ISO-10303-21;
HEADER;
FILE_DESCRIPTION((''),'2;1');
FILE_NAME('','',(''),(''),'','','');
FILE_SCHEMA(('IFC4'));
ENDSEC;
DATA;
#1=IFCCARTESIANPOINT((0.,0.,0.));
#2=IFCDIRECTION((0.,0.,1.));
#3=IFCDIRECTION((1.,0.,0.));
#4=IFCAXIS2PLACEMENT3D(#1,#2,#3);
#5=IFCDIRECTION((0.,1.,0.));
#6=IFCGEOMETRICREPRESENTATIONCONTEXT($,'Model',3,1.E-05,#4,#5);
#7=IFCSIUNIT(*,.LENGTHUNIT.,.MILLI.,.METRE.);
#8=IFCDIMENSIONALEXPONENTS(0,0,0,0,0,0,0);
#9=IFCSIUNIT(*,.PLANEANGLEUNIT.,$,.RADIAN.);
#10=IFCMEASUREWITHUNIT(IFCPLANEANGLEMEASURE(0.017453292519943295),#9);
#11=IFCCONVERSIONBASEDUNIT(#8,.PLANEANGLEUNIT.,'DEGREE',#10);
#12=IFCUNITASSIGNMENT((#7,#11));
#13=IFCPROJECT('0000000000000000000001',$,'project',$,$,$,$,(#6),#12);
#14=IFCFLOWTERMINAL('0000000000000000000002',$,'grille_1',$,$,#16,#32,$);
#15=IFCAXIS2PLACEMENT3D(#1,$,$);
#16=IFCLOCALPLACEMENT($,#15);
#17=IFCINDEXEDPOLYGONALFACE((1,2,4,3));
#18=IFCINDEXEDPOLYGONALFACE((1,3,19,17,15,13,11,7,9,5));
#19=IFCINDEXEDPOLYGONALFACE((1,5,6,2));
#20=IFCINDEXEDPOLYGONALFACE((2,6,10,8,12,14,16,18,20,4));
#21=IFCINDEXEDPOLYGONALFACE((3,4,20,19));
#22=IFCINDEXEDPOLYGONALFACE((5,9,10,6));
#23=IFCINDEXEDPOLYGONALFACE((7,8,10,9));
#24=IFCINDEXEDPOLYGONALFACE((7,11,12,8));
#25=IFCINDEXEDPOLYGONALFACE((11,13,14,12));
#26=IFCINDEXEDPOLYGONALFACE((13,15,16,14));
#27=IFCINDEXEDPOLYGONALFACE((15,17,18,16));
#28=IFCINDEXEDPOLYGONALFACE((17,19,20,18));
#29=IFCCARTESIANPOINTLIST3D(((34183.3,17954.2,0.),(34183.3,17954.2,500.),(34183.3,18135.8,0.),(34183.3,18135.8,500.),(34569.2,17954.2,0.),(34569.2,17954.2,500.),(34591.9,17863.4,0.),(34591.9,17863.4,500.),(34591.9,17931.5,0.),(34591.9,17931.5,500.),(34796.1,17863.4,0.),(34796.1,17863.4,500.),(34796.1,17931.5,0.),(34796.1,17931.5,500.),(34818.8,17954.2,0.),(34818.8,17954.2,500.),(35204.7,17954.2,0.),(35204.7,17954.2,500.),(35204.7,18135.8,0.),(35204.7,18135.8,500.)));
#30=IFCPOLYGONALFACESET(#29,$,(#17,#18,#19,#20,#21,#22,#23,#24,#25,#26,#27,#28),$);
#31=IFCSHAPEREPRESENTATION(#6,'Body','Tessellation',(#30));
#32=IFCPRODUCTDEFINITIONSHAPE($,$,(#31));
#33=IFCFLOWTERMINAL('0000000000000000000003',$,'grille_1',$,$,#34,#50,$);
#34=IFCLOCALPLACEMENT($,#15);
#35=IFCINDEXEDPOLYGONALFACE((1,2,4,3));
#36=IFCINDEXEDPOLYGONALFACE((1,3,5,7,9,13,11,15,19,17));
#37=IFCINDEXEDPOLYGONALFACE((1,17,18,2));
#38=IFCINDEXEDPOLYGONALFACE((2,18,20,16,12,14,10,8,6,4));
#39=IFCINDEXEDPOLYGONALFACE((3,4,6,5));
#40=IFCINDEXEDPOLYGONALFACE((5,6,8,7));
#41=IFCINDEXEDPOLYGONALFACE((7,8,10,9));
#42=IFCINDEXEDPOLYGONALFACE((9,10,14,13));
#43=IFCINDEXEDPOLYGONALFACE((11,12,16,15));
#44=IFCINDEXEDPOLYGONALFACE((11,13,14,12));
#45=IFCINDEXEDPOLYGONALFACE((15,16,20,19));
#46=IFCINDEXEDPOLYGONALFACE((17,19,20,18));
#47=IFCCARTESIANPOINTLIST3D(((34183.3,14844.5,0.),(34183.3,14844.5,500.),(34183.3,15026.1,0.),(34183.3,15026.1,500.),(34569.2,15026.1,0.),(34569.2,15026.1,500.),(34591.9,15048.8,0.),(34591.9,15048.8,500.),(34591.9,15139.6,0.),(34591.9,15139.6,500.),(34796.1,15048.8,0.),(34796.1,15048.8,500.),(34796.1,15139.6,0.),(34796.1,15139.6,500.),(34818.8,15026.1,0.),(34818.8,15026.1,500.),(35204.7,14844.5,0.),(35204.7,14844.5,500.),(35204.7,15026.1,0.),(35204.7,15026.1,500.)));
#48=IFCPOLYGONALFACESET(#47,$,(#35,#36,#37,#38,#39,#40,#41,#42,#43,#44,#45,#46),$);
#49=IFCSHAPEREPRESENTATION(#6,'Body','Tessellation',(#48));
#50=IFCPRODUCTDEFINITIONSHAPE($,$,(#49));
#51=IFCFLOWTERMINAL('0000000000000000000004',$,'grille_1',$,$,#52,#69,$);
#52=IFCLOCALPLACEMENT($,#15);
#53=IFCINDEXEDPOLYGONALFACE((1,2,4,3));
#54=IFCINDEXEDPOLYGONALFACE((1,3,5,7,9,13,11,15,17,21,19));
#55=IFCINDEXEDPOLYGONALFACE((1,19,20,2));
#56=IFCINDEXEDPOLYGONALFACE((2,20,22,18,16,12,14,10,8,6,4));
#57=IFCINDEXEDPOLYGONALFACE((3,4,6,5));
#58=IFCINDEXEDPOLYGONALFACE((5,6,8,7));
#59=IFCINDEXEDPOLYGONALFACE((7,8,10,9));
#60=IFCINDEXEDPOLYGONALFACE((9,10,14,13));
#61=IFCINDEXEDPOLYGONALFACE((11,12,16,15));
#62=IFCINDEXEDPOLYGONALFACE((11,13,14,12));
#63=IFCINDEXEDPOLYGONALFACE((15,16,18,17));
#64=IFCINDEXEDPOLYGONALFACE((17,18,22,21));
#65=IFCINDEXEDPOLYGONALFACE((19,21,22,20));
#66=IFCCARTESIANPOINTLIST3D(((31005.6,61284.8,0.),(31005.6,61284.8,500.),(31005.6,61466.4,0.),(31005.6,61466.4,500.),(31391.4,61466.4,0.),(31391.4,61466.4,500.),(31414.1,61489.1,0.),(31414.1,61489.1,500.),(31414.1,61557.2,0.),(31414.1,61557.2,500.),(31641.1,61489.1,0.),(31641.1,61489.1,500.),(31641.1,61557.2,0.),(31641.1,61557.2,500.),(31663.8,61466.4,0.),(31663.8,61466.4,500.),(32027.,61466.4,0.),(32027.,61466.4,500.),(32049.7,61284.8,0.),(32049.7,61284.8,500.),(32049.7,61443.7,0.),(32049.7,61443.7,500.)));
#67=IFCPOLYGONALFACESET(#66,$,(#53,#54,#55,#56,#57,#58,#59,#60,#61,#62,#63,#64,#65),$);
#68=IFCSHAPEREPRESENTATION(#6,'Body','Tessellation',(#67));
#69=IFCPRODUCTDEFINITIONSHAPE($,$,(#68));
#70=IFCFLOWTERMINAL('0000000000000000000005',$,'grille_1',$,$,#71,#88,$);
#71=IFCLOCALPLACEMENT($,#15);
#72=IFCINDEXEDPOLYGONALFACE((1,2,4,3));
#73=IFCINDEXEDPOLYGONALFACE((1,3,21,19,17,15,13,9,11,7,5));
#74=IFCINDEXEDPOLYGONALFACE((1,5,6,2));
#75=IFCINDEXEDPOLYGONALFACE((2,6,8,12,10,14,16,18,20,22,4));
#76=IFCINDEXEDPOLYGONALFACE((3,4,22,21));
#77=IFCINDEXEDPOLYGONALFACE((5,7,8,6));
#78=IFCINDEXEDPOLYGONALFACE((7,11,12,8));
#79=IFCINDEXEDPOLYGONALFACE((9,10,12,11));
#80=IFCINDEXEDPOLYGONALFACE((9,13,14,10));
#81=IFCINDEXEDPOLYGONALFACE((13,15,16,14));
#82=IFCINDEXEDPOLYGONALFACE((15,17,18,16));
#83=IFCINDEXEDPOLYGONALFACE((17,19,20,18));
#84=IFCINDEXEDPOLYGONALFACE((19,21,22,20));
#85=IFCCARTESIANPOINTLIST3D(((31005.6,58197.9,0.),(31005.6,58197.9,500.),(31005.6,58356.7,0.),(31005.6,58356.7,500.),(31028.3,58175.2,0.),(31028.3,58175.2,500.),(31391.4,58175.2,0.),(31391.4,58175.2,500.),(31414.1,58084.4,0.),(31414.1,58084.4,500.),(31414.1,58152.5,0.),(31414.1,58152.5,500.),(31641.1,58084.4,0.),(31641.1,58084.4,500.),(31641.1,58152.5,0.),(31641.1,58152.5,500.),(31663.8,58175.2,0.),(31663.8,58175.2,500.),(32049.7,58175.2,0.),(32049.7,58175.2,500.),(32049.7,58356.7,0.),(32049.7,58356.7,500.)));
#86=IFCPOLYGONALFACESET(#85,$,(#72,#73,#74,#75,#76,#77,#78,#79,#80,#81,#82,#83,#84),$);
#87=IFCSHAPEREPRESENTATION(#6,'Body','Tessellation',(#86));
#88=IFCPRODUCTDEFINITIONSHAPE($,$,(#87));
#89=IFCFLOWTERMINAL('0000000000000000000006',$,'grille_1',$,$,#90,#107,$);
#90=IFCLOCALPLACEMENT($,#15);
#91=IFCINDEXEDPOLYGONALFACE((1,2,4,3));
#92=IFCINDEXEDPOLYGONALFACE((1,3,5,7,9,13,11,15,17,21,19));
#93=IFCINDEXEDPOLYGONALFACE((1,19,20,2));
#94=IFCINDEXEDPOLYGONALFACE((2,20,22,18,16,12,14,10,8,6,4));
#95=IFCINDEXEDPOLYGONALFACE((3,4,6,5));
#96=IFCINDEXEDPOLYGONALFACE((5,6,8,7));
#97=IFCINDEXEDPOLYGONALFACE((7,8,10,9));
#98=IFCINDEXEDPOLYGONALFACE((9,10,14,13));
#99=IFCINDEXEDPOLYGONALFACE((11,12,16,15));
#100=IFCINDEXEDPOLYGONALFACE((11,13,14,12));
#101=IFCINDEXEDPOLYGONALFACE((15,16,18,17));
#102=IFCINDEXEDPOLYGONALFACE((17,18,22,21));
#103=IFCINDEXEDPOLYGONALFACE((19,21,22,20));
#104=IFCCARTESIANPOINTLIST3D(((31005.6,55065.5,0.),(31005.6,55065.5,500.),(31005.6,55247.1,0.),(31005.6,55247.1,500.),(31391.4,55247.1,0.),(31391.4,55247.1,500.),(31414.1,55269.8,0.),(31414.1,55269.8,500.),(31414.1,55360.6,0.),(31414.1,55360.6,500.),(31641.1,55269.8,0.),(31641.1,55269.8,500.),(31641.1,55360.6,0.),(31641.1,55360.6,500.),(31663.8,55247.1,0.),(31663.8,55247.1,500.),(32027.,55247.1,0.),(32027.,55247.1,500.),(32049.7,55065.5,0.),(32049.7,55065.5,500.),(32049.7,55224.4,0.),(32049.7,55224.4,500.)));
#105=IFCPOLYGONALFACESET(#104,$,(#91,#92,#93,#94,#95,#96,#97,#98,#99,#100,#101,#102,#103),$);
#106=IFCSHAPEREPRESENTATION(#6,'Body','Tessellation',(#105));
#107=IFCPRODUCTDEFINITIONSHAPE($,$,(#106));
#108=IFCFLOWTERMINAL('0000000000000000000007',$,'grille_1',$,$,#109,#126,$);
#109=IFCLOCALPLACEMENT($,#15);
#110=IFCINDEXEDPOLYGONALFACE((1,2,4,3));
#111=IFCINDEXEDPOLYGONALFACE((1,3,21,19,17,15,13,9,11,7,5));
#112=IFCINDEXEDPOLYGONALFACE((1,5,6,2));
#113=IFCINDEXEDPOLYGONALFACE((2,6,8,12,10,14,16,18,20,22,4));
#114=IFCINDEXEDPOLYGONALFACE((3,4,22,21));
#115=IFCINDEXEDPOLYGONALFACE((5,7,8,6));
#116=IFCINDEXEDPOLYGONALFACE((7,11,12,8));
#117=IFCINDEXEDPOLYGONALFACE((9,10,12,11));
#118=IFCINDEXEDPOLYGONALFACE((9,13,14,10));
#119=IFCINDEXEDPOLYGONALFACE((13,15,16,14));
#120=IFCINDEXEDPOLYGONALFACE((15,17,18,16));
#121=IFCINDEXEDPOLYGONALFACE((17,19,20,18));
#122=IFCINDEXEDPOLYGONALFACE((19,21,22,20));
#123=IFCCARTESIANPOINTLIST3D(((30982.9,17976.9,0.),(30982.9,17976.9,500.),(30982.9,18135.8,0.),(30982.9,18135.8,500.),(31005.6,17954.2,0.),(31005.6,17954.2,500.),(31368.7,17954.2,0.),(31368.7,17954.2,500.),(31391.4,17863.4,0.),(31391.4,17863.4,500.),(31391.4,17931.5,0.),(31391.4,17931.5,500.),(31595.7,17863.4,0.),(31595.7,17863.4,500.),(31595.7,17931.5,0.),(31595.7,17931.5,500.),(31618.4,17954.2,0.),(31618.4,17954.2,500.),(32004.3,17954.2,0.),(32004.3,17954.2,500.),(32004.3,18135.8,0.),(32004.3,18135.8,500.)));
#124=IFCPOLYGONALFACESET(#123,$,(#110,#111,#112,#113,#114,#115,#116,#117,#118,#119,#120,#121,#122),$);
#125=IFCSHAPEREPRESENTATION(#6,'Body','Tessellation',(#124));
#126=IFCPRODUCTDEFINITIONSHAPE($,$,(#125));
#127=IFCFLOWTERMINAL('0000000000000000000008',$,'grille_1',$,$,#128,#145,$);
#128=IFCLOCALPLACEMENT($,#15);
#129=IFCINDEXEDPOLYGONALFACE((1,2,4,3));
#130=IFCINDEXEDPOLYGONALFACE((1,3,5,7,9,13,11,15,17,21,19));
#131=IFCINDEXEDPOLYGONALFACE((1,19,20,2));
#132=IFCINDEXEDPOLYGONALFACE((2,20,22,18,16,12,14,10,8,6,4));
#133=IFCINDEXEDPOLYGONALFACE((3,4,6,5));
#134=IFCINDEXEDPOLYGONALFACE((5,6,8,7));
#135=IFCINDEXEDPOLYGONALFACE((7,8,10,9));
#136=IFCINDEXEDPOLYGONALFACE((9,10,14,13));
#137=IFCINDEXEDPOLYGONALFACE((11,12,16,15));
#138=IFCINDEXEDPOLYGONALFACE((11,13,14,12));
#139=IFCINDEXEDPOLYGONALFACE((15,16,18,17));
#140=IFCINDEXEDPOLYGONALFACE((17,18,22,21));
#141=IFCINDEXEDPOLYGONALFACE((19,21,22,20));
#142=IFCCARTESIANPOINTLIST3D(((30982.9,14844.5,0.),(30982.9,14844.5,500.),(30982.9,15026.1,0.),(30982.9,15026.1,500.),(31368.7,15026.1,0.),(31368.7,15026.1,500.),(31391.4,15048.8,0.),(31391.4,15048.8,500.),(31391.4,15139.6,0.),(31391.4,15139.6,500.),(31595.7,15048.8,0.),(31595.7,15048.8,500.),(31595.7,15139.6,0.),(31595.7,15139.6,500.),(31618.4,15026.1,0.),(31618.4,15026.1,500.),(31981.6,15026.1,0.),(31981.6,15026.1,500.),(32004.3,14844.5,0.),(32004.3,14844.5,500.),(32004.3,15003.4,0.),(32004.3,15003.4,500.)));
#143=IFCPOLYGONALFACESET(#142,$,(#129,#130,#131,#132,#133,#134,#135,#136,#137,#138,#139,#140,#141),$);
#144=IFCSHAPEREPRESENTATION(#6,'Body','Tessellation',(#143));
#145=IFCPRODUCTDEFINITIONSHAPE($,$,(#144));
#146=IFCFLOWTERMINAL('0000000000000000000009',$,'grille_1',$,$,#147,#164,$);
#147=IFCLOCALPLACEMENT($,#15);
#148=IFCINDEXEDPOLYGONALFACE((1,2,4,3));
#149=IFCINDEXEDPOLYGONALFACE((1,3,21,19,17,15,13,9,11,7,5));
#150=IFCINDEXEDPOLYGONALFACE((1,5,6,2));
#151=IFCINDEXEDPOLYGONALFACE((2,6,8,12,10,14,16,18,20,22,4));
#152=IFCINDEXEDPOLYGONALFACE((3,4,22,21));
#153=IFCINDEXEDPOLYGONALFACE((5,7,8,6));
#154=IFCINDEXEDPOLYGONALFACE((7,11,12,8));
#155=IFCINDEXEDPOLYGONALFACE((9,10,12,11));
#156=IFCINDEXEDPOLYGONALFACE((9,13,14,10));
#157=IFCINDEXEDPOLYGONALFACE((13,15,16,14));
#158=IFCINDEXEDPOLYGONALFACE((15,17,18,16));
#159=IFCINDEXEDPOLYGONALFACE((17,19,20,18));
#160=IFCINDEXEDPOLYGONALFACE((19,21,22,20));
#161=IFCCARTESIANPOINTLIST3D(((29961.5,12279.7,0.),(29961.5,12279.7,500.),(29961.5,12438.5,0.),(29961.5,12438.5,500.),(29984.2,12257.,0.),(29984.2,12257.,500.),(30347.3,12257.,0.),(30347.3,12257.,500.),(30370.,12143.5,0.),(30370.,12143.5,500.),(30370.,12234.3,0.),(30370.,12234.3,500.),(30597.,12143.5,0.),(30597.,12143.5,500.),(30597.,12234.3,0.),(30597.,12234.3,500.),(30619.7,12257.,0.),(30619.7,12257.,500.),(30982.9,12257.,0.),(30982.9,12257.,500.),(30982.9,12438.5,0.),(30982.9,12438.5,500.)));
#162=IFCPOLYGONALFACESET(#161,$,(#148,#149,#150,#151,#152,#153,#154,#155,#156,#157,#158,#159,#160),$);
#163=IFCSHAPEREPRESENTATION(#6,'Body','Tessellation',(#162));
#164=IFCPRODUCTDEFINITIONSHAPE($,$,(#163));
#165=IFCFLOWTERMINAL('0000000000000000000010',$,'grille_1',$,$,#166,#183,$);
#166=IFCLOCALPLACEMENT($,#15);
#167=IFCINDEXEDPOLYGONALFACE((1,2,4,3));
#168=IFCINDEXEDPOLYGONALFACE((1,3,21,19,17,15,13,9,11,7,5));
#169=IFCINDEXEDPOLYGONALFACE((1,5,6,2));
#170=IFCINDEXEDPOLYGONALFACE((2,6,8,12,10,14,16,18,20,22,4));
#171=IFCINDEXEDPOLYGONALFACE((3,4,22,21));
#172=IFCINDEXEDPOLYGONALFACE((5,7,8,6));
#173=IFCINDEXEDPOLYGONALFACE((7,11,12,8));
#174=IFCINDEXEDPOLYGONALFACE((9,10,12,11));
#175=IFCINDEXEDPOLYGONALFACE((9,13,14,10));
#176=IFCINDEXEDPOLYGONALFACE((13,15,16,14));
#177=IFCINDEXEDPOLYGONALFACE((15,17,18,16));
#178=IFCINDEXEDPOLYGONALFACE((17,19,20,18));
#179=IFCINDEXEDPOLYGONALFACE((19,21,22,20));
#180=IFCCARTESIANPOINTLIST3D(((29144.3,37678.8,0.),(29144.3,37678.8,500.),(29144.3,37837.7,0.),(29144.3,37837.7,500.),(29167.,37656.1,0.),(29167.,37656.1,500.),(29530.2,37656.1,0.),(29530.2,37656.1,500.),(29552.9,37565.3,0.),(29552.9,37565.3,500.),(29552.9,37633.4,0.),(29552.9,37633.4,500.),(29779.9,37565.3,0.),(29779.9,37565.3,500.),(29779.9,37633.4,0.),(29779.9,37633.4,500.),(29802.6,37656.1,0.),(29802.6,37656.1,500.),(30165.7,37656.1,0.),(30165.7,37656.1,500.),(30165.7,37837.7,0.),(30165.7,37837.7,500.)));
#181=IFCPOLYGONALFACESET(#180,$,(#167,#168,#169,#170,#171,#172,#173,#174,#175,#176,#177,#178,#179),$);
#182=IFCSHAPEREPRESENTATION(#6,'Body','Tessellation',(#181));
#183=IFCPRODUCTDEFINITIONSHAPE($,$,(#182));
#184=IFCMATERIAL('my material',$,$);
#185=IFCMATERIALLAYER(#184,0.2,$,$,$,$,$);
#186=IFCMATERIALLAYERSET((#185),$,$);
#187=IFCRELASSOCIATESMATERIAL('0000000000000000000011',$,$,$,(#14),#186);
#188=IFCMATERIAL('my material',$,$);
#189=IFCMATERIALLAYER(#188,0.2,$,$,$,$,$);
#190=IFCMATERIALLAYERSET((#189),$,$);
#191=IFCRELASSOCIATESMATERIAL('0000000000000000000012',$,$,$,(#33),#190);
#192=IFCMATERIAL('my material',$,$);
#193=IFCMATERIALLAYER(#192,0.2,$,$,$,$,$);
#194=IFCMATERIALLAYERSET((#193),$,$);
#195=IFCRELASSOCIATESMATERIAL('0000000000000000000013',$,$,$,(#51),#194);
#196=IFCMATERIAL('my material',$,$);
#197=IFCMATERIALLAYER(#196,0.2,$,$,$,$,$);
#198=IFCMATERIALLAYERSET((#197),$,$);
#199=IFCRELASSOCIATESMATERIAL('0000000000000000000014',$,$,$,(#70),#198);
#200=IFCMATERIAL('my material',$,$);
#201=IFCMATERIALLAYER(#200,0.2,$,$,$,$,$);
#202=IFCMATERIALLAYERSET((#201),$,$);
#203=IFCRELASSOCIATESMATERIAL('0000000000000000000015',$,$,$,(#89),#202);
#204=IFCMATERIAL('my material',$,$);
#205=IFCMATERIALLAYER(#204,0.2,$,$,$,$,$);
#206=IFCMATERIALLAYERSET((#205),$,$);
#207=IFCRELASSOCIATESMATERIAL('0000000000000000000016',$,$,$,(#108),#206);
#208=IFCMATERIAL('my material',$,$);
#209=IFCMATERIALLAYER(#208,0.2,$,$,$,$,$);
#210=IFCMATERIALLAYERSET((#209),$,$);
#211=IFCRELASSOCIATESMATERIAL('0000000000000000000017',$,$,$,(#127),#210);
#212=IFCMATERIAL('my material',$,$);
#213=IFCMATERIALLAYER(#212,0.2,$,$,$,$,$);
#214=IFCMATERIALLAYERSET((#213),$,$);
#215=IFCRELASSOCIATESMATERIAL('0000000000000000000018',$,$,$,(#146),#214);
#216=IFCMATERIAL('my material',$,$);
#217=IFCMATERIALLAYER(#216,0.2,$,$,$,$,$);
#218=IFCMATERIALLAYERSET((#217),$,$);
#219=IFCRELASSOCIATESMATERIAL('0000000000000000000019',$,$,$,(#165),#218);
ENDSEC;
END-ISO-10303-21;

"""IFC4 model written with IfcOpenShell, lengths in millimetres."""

from ifc_helpers import new_model, entity, si_unit, converted_unit, direction, origin_with_axes, place, context, project, polyline, outline, extrude, material, layer, layer_set, layer_usage, element, save


model = new_model("IFC4")

# Units and contexts
model_context = context("Model", 3, precision=1e-05, world=origin_with_axes(), true_north=direction((0.0, 1.0, 0.0)))
ifc_project = project(units=[si_unit("LENGTHUNIT", "METRE", prefix="MILLI"), converted_unit("PLANEANGLEUNIT", "DEGREE", entity("IfcPlaneAngleMeasure", 0.017453292519943295), si_unit("PLANEANGLEUNIT", "RADIAN"), dimensions=[0, 0, 0, 0, 0, 0, 0])], contexts=[model_context])

# Flow terminals
ifc_material_1 = material(Name="my material")
ifc_layer_1 = layer(ifc_material_1, 0.2)
ifc_layer_set_1 = layer_set([ifc_layer_1])
ifc_layer_usage_1 = layer_usage(ifc_layer_set_1, "AXIS2", "POSITIVE", -0.1)
flow_terminal_1_placement = place(None, origin_with_axes())
element("IfcFlowTerminal", 1, at=flow_terminal_1_placement, material=ifc_layer_usage_1, Name="grille_1", context=model_context, shape_type="SweptSolid", body=[
    extrude(outline(polyline([(34183.3, 17954.2), (34569.2, 17954.2), (34591.9, 17931.5), (34591.9, 17863.4), (34796.1, 17863.4), (34796.1, 17931.5), (34818.8, 17954.2), (35204.7, 17954.2), (35204.7, 18135.8), (34183.3, 18135.8), (34183.3, 17954.2)])), origin_with_axes(), (0.0, 0.0, 1.0), 500.0),
])
ifc_material_2 = material(Name="my material")
ifc_layer_2 = layer(ifc_material_2, 0.2)
ifc_layer_set_2 = layer_set([ifc_layer_2])
ifc_layer_usage_2 = layer_usage(ifc_layer_set_2, "AXIS2", "POSITIVE", -0.1)
flow_terminal_2_placement = place(None, origin_with_axes())
element("IfcFlowTerminal", 2, at=flow_terminal_2_placement, material=ifc_layer_usage_2, Name="grille_1", context=model_context, shape_type="SweptSolid", body=[
    extrude(outline(polyline([(34183.3, 14844.5), (35204.7, 14844.5), (35204.7, 15026.1), (34818.8, 15026.1), (34796.1, 15048.8), (34796.1, 15139.6), (34591.9, 15139.6), (34591.9, 15048.8), (34569.2, 15026.1), (34183.3, 15026.1), (34183.3, 14844.5)])), origin_with_axes(), (0.0, 0.0, 1.0), 500.0),
])
ifc_material_3 = material(Name="my material")
ifc_layer_3 = layer(ifc_material_3, 0.2)
ifc_layer_set_3 = layer_set([ifc_layer_3])
ifc_layer_usage_3 = layer_usage(ifc_layer_set_3, "AXIS2", "POSITIVE", -0.1)
flow_terminal_3_placement = place(None, origin_with_axes())
element("IfcFlowTerminal", 3, at=flow_terminal_3_placement, material=ifc_layer_usage_3, Name="grille_1", context=model_context, shape_type="SweptSolid", body=[
    extrude(outline(polyline([(31005.6, 61284.8), (32049.7, 61284.8), (32049.7, 61443.7), (32027.0, 61466.4), (31663.8, 61466.4), (31641.1, 61489.1), (31641.1, 61557.2), (31414.1, 61557.2), (31414.1, 61489.1), (31391.4, 61466.4), (31005.6, 61466.4), (31005.6, 61284.8)])), origin_with_axes(), (0.0, 0.0, 1.0), 500.0),
])
ifc_material_4 = material(Name="my material")
ifc_layer_4 = layer(ifc_material_4, 0.2)
ifc_layer_set_4 = layer_set([ifc_layer_4])
ifc_layer_usage_4 = layer_usage(ifc_layer_set_4, "AXIS2", "POSITIVE", -0.1)
flow_terminal_4_placement = place(None, origin_with_axes())
element("IfcFlowTerminal", 4, at=flow_terminal_4_placement, material=ifc_layer_usage_4, Name="grille_1", context=model_context, shape_type="SweptSolid", body=[
    extrude(outline(polyline([(31005.6, 58197.9), (31028.3, 58175.2), (31391.4, 58175.2), (31414.1, 58152.5), (31414.1, 58084.4), (31641.1, 58084.4), (31641.1, 58152.5), (31663.8, 58175.2), (32049.7, 58175.2), (32049.7, 58356.7), (31005.6, 58356.7), (31005.6, 58197.9)])), origin_with_axes(), (0.0, 0.0, 1.0), 500.0),
])
ifc_material_5 = material(Name="my material")
ifc_layer_5 = layer(ifc_material_5, 0.2)
ifc_layer_set_5 = layer_set([ifc_layer_5])
ifc_layer_usage_5 = layer_usage(ifc_layer_set_5, "AXIS2", "POSITIVE", -0.1)
flow_terminal_5_placement = place(None, origin_with_axes())
element("IfcFlowTerminal", 5, at=flow_terminal_5_placement, material=ifc_layer_usage_5, Name="grille_1", context=model_context, shape_type="SweptSolid", body=[
    extrude(outline(polyline([(31005.6, 55065.5), (32049.7, 55065.5), (32049.7, 55224.4), (32027.0, 55247.1), (31663.8, 55247.1), (31641.1, 55269.8), (31641.1, 55360.6), (31414.1, 55360.6), (31414.1, 55269.8), (31391.4, 55247.1), (31005.6, 55247.1), (31005.6, 55065.5)])), origin_with_axes(), (0.0, 0.0, 1.0), 500.0),
])
ifc_material_6 = material(Name="my material")
ifc_layer_6 = layer(ifc_material_6, 0.2)
ifc_layer_set_6 = layer_set([ifc_layer_6])
ifc_layer_usage_6 = layer_usage(ifc_layer_set_6, "AXIS2", "POSITIVE", -0.1)
flow_terminal_6_placement = place(None, origin_with_axes())
element("IfcFlowTerminal", 6, at=flow_terminal_6_placement, material=ifc_layer_usage_6, Name="grille_1", context=model_context, shape_type="SweptSolid", body=[
    extrude(outline(polyline([(30982.9, 17976.9), (31005.6, 17954.2), (31368.7, 17954.2), (31391.4, 17931.5), (31391.4, 17863.4), (31595.7, 17863.4), (31595.7, 17931.5), (31618.4, 17954.2), (32004.3, 17954.2), (32004.3, 18135.8), (30982.9, 18135.8), (30982.9, 17976.9)])), origin_with_axes(), (0.0, 0.0, 1.0), 500.0),
])
ifc_material_7 = material(Name="my material")
ifc_layer_7 = layer(ifc_material_7, 0.2)
ifc_layer_set_7 = layer_set([ifc_layer_7])
ifc_layer_usage_7 = layer_usage(ifc_layer_set_7, "AXIS2", "POSITIVE", -0.1)
flow_terminal_7_placement = place(None, origin_with_axes())
element("IfcFlowTerminal", 7, at=flow_terminal_7_placement, material=ifc_layer_usage_7, Name="grille_1", context=model_context, shape_type="SweptSolid", body=[
    extrude(outline(polyline([(30982.9, 14844.5), (32004.3, 14844.5), (32004.3, 15003.4), (31981.6, 15026.1), (31618.4, 15026.1), (31595.7, 15048.8), (31595.7, 15139.6), (31391.4, 15139.6), (31391.4, 15048.8), (31368.7, 15026.1), (30982.9, 15026.1), (30982.9, 14844.5)])), origin_with_axes(), (0.0, 0.0, 1.0), 500.0),
])
ifc_material_8 = material(Name="my material")
ifc_layer_8 = layer(ifc_material_8, 0.2)
ifc_layer_set_8 = layer_set([ifc_layer_8])
ifc_layer_usage_8 = layer_usage(ifc_layer_set_8, "AXIS2", "POSITIVE", -0.1)
flow_terminal_8_placement = place(None, origin_with_axes())
element("IfcFlowTerminal", 8, at=flow_terminal_8_placement, material=ifc_layer_usage_8, Name="grille_1", context=model_context, shape_type="SweptSolid", body=[
    extrude(outline(polyline([(29961.5, 12279.7), (29984.2, 12257.0), (30347.3, 12257.0), (30370.0, 12234.3), (30370.0, 12143.5), (30597.0, 12143.5), (30597.0, 12234.3), (30619.7, 12257.0), (30982.9, 12257.0), (30982.9, 12438.5), (29961.5, 12438.5), (29961.5, 12279.7)])), origin_with_axes(), (0.0, 0.0, 1.0), 500.0),
])
ifc_material_9 = material(Name="my material")
ifc_layer_9 = layer(ifc_material_9, 0.2)
ifc_layer_set_9 = layer_set([ifc_layer_9])
ifc_layer_usage_9 = layer_usage(ifc_layer_set_9, "AXIS2", "POSITIVE", -0.1)
flow_terminal_9_placement = place(None, origin_with_axes())
element("IfcFlowTerminal", 9, at=flow_terminal_9_placement, material=ifc_layer_usage_9, Name="grille_1", context=model_context, shape_type="SweptSolid", body=[
    extrude(outline(polyline([(29144.3, 37678.8), (29167.0, 37656.1), (29530.2, 37656.1), (29552.9, 37633.4), (29552.9, 37565.3), (29779.9, 37565.3), (29779.9, 37633.4), (29802.6, 37656.1), (30165.7, 37656.1), (30165.7, 37837.7), (29144.3, 37837.7), (29144.3, 37678.8)])), origin_with_axes(), (0.0, 0.0, 1.0), 500.0),
])

save(model, "model.ifc")
